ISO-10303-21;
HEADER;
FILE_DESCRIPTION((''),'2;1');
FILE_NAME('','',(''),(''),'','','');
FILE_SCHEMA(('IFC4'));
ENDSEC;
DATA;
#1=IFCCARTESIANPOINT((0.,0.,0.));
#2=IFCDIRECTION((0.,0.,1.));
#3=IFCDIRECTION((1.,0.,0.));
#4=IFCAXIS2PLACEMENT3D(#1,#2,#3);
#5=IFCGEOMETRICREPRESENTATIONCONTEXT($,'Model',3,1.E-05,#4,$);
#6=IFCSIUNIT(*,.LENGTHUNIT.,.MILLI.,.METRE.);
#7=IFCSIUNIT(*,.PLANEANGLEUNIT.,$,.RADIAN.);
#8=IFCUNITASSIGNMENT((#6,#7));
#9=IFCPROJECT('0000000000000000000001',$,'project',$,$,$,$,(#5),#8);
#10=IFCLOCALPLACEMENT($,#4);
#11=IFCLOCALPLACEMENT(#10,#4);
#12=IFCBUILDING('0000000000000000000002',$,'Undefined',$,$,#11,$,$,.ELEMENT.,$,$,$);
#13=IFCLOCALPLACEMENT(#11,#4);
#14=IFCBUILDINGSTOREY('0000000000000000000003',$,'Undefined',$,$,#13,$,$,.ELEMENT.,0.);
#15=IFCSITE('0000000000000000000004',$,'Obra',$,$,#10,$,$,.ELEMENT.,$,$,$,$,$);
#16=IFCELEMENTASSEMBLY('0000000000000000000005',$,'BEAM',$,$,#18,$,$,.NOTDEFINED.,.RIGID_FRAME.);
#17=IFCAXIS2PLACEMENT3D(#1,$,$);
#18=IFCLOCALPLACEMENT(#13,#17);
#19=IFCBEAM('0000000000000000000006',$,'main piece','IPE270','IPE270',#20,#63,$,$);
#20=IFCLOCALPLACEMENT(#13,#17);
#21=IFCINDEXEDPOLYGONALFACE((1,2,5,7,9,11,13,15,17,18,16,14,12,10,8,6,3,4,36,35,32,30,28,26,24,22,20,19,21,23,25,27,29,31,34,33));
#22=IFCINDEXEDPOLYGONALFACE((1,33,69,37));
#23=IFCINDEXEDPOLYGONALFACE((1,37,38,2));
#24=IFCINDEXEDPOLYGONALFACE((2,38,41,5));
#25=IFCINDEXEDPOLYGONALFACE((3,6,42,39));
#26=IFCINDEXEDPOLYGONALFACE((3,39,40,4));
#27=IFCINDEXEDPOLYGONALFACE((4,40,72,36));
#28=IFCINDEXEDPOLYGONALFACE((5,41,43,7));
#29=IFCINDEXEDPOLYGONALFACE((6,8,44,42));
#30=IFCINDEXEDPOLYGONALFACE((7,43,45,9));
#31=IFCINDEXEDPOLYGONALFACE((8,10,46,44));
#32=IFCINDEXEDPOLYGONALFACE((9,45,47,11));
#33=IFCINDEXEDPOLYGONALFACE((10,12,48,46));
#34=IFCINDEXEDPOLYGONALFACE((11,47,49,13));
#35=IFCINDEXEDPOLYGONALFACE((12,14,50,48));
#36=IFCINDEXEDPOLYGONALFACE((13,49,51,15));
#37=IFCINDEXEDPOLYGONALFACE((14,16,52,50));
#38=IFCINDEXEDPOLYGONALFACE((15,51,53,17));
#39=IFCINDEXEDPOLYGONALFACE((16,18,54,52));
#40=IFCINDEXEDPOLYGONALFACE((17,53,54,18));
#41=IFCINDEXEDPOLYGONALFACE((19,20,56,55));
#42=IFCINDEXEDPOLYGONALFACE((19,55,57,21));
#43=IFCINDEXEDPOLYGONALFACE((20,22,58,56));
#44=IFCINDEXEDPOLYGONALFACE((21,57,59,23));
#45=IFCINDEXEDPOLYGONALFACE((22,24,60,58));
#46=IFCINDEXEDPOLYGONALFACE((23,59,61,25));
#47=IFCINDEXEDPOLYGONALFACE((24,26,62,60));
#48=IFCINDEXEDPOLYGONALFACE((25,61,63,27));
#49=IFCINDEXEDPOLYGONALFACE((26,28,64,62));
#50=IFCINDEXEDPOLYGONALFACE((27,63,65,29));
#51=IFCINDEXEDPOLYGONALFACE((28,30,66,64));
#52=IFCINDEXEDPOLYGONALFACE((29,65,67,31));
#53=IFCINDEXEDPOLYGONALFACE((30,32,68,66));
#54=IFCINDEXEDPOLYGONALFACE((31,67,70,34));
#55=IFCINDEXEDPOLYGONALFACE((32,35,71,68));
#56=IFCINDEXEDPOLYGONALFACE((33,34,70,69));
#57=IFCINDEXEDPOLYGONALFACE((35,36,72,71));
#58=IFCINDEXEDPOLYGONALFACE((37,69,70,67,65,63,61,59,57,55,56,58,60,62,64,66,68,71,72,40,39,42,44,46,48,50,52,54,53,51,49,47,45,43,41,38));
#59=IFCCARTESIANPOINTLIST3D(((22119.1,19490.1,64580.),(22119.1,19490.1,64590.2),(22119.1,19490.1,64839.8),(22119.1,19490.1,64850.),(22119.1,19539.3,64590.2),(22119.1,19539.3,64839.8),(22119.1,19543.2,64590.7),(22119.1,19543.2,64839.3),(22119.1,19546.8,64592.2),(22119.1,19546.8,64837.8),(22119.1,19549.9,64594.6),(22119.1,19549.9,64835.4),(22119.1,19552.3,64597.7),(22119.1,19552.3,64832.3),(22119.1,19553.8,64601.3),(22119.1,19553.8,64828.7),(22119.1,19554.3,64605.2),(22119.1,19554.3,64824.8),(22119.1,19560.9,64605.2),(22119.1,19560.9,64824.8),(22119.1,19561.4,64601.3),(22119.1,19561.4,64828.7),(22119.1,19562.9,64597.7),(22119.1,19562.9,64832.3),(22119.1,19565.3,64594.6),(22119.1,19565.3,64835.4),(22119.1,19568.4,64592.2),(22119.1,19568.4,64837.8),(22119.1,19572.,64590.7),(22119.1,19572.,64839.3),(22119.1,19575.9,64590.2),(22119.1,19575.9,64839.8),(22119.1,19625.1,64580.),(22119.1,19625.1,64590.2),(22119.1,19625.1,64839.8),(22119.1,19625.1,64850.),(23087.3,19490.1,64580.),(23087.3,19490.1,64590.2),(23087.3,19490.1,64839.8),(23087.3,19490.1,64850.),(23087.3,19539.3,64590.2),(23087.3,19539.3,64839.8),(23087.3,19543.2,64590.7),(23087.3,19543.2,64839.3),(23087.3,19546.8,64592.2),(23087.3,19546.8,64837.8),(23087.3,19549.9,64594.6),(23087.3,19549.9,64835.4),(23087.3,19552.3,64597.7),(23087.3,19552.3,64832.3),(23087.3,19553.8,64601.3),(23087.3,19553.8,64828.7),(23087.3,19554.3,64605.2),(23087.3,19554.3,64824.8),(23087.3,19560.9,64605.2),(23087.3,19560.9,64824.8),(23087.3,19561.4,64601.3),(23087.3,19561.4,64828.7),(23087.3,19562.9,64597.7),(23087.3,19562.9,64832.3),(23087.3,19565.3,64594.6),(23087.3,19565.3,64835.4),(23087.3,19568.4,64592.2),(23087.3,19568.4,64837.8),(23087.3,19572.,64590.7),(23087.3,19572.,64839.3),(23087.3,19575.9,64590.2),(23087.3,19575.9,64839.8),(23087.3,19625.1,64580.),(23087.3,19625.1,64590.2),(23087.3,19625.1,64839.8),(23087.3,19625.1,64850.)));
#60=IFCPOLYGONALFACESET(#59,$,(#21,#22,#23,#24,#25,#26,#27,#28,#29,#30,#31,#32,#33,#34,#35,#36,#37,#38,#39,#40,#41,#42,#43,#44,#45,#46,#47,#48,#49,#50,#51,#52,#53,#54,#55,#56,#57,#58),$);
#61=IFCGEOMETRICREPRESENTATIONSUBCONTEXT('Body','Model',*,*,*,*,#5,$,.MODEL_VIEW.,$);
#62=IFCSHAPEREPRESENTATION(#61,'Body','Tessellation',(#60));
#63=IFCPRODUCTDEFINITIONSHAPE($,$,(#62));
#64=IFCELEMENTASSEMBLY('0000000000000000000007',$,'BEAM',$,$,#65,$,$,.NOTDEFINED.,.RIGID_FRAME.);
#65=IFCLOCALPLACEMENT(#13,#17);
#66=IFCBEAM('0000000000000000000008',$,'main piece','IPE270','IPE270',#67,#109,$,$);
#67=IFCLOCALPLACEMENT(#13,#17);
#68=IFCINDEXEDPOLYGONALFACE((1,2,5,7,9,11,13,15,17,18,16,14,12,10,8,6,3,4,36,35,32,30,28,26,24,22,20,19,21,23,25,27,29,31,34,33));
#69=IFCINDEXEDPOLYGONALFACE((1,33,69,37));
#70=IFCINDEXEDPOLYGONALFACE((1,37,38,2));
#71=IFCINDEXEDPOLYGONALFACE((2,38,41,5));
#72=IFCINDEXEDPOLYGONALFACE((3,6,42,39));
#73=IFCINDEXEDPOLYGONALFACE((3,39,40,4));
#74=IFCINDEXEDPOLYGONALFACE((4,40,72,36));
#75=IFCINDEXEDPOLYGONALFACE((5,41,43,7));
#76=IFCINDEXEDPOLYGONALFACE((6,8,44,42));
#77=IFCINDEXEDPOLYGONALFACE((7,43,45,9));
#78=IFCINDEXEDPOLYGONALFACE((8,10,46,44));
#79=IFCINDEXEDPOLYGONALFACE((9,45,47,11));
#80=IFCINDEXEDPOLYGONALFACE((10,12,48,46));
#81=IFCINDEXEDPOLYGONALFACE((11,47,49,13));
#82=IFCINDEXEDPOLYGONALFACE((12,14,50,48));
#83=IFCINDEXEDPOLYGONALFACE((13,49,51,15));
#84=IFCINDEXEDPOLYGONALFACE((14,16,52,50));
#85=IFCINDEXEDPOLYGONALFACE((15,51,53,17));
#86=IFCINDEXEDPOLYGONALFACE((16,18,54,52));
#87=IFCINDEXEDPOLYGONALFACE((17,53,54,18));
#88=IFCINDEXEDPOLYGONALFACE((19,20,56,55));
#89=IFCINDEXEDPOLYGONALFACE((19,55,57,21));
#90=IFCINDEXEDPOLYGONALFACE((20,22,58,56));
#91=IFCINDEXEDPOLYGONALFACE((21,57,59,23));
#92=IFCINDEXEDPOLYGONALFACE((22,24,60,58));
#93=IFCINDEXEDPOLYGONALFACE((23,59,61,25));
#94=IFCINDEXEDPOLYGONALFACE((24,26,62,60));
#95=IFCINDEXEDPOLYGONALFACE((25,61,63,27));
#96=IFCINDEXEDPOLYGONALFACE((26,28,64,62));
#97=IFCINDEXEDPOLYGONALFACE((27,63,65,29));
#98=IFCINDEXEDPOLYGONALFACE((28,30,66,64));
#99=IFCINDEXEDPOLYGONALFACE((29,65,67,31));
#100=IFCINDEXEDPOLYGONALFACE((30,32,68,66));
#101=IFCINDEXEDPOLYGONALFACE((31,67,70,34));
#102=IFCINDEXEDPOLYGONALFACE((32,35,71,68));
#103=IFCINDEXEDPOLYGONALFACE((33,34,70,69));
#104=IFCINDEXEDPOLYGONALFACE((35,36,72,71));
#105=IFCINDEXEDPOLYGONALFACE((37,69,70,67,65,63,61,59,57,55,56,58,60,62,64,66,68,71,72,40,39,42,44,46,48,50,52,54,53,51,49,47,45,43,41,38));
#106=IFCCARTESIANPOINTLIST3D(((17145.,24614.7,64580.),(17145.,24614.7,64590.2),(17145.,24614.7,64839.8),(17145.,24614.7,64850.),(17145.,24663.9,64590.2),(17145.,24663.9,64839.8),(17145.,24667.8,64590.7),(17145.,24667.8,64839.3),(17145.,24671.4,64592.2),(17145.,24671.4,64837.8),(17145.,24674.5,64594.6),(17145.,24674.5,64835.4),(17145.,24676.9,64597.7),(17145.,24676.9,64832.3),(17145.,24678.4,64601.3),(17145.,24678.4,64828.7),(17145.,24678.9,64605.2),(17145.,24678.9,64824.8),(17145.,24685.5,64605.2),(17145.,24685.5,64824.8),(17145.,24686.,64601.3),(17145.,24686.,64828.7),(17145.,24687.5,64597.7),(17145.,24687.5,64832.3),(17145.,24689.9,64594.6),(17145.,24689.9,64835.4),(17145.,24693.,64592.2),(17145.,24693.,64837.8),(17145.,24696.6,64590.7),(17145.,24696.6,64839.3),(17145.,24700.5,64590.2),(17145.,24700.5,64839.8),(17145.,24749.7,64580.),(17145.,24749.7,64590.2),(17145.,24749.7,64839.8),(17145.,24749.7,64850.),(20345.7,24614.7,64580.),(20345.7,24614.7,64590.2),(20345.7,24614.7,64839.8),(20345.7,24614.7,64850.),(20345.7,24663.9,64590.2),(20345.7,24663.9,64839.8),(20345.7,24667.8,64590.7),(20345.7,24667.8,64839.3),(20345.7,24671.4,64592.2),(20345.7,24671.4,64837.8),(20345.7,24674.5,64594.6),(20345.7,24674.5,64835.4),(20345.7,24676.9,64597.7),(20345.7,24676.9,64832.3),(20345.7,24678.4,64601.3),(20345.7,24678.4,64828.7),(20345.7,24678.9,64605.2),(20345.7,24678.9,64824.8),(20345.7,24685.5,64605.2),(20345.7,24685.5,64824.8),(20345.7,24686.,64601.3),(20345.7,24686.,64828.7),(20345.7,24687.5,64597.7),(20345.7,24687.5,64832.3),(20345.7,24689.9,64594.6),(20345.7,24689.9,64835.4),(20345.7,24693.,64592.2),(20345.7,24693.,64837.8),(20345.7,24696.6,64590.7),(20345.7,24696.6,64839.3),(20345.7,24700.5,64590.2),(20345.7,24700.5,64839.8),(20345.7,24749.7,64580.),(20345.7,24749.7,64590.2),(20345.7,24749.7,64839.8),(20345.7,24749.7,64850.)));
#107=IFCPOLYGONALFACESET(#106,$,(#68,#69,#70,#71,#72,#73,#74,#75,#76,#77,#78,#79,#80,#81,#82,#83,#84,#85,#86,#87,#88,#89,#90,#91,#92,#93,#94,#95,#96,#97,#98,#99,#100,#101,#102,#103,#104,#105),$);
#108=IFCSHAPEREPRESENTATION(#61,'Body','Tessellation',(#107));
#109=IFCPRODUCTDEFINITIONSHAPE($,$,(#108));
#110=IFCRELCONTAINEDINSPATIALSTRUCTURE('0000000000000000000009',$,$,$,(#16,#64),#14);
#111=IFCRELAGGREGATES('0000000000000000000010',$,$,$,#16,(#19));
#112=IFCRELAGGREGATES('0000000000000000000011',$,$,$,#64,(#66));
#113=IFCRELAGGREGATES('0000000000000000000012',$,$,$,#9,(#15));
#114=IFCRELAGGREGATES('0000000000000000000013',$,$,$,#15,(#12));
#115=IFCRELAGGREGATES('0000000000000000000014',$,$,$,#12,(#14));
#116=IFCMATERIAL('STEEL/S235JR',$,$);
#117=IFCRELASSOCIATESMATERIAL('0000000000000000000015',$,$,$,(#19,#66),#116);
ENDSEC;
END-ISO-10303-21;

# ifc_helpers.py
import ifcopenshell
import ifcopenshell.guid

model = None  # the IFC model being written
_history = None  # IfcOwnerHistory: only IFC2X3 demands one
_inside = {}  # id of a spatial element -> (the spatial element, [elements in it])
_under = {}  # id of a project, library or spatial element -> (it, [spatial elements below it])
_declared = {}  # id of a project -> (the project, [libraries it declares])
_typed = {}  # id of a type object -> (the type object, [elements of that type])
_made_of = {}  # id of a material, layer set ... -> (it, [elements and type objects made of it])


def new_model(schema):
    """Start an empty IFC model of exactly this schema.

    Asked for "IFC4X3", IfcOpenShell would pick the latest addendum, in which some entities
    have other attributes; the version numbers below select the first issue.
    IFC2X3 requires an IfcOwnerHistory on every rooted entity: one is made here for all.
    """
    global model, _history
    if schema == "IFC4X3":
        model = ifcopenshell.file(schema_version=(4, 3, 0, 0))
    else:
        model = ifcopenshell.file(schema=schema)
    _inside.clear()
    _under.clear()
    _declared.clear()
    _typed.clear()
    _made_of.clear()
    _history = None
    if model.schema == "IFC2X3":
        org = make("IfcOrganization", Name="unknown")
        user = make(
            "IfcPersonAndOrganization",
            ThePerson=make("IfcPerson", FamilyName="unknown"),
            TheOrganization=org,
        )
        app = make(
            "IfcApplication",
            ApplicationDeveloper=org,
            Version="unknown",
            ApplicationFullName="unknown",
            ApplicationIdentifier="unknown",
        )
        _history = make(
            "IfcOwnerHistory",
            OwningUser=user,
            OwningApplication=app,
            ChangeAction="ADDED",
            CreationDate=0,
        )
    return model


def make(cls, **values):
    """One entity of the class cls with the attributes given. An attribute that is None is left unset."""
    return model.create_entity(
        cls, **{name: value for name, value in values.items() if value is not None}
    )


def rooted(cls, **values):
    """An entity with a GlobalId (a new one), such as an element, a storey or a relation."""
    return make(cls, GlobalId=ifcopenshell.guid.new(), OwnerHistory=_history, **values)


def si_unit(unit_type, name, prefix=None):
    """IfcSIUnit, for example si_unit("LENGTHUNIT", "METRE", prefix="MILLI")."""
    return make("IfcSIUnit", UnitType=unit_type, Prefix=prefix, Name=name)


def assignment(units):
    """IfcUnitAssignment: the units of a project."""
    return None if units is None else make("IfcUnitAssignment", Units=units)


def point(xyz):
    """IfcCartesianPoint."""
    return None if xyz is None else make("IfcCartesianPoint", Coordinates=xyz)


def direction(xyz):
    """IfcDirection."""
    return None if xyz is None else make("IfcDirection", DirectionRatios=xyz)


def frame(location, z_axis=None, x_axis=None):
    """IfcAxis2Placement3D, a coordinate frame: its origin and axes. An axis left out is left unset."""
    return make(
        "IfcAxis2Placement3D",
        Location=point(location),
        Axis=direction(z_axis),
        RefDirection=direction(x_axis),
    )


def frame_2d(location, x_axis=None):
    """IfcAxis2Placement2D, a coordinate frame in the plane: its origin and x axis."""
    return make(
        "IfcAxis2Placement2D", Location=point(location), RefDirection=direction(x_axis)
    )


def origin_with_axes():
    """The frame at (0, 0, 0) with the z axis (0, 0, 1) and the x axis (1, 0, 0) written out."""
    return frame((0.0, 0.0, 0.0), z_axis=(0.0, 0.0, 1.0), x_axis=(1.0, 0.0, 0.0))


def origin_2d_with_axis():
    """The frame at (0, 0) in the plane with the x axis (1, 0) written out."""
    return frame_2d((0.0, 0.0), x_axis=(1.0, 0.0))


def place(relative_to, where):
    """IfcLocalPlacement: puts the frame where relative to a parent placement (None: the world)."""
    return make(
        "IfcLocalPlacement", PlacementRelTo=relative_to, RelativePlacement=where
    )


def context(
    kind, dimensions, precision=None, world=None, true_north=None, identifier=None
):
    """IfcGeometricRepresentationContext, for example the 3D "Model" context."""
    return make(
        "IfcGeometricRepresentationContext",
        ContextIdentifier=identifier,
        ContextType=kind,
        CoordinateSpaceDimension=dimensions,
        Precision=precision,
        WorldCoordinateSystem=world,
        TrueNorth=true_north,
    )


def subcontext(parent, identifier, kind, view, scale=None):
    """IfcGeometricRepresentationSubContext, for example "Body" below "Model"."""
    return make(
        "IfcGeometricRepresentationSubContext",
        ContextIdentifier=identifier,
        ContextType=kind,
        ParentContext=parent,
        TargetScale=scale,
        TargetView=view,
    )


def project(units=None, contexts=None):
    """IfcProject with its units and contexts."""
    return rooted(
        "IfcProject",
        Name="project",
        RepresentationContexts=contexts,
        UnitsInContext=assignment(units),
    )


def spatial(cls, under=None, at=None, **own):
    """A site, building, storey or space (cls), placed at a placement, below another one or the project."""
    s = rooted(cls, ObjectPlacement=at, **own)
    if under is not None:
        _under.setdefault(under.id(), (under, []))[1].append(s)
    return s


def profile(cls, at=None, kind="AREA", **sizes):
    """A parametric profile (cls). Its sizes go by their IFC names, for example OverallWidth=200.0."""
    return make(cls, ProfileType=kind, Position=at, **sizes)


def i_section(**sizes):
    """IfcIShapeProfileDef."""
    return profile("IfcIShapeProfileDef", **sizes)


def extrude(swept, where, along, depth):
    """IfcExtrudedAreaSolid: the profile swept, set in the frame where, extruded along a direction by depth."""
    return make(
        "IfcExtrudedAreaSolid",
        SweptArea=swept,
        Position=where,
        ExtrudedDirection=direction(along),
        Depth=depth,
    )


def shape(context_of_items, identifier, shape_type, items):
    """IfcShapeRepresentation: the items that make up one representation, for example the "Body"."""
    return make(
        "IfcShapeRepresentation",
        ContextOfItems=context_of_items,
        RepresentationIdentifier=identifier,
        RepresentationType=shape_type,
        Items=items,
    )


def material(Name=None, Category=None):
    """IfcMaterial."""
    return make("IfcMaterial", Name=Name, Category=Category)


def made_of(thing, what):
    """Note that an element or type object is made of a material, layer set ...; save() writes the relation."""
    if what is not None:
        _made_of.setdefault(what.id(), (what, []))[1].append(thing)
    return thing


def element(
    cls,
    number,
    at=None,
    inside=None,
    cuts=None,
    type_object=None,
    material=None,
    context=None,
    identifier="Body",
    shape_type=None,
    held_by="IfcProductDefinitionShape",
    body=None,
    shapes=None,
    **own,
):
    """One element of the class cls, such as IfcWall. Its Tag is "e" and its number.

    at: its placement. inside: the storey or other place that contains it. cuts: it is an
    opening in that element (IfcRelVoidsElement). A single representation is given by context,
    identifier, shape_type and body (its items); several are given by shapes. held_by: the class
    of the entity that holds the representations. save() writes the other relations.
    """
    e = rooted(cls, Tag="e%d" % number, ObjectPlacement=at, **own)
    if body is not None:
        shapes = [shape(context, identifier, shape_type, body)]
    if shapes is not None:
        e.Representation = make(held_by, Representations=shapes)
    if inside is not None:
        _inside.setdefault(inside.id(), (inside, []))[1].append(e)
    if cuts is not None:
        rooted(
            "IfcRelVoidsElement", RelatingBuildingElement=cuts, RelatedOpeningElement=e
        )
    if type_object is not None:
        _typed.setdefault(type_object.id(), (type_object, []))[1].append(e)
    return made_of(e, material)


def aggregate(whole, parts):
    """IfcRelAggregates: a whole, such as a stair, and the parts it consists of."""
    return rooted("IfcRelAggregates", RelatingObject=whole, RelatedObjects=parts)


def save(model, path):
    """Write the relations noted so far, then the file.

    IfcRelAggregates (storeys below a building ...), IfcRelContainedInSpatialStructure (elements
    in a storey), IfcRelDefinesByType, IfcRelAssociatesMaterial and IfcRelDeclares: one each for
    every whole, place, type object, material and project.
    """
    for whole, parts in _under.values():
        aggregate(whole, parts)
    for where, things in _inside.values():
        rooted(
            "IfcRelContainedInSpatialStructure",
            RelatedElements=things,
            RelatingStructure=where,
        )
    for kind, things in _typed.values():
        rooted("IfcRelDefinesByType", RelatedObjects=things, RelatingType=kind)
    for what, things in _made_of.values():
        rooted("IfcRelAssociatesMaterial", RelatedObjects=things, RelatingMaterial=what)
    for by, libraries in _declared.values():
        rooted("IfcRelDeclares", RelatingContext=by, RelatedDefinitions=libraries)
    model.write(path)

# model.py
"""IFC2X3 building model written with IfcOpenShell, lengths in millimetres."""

from ifc_helpers import new_model, si_unit, frame, origin_with_axes, origin_2d_with_axis, place, context, subcontext, project, spatial, i_section, extrude, material, element, aggregate, save


model = new_model("IFC2X3")

# Units and contexts
model_context = context("Model", 3, precision=1e-05, world=origin_with_axes())
body_context = subcontext(model_context, "Body", "Model", "MODEL_VIEW")
ifc_project = project(units=[si_unit("LENGTHUNIT", "METRE", prefix="MILLI"), si_unit("PLANEANGLEUNIT", "RADIAN")], contexts=[model_context])

# Site, building, storey
site_placement = place(None, origin_with_axes())
site = spatial("IfcSite", under=ifc_project, at=site_placement, Name="Obra", CompositionType="ELEMENT")
building_placement = place(site_placement, origin_with_axes())
building = spatial("IfcBuilding", under=site, at=building_placement, Name="Undefined", CompositionType="ELEMENT")
storey_placement = place(building_placement, origin_with_axes())
storey = spatial("IfcBuildingStorey", under=building, at=storey_placement, Name="Undefined", CompositionType="ELEMENT", Elevation=0.0)

# Shared definitions
ifc_material_1 = material(Name="STEEL/S235JR")

# Element assemblies, beams
assembly_1_placement = place(storey_placement, origin_with_axes())
assembly_1 = element("IfcElementAssembly", 1, at=assembly_1_placement, inside=storey, Name="BEAM", AssemblyPlace="NOTDEFINED", PredefinedType="RIGID_FRAME")
beam_1_placement = place(assembly_1_placement, frame((22119.1, 19557.6, 64715.0), z_axis=(0.0, 0.0, 1.0), x_axis=(1.0, 0.0, 0.0)))
beam_1 = element("IfcBeam", 2, at=beam_1_placement, material=ifc_material_1, Name="main piece", Description="IPE270", ObjectType="IPE270", context=body_context, shape_type="SweptSolid", body=[
    extrude(i_section(OverallWidth=135.0, OverallDepth=270.0, WebThickness=6.6, FlangeThickness=10.2, FilletRadius=15.0, at=origin_2d_with_axis()), frame((968.2, 0.0, 0.0), z_axis=(-1.0, 0.0, 0.0), x_axis=(0.0, -1.0, 0.0)), (0.0, 0.0, 1.0), 968.2),
])
aggregate(assembly_1, [beam_1])
assembly_2_placement = place(storey_placement, origin_with_axes())
assembly_2 = element("IfcElementAssembly", 3, at=assembly_2_placement, inside=storey, Name="BEAM", AssemblyPlace="NOTDEFINED", PredefinedType="RIGID_FRAME")
beam_2_placement = place(assembly_2_placement, frame((17145.0, 24682.2, 64715.0), z_axis=(0.0, 0.0, 1.0), x_axis=(1.0, 0.000002, 0.0)))
beam_2 = element("IfcBeam", 4, at=beam_2_placement, material=ifc_material_1, Name="main piece", Description="IPE270", ObjectType="IPE270", context=body_context, shape_type="SweptSolid", body=[
    extrude(i_section(OverallWidth=135.0, OverallDepth=270.0, WebThickness=6.6, FlangeThickness=10.2, FilletRadius=15.0, at=origin_2d_with_axis()), frame((3200.7, 0.0, 0.0), z_axis=(-1.0, 0.0, 0.0), x_axis=(0.0, -1.0, 0.0)), (0.0, 0.0, 1.0), 3200.7),
])

aggregate(assembly_2, [beam_2])

save(model, "model.ifc")
